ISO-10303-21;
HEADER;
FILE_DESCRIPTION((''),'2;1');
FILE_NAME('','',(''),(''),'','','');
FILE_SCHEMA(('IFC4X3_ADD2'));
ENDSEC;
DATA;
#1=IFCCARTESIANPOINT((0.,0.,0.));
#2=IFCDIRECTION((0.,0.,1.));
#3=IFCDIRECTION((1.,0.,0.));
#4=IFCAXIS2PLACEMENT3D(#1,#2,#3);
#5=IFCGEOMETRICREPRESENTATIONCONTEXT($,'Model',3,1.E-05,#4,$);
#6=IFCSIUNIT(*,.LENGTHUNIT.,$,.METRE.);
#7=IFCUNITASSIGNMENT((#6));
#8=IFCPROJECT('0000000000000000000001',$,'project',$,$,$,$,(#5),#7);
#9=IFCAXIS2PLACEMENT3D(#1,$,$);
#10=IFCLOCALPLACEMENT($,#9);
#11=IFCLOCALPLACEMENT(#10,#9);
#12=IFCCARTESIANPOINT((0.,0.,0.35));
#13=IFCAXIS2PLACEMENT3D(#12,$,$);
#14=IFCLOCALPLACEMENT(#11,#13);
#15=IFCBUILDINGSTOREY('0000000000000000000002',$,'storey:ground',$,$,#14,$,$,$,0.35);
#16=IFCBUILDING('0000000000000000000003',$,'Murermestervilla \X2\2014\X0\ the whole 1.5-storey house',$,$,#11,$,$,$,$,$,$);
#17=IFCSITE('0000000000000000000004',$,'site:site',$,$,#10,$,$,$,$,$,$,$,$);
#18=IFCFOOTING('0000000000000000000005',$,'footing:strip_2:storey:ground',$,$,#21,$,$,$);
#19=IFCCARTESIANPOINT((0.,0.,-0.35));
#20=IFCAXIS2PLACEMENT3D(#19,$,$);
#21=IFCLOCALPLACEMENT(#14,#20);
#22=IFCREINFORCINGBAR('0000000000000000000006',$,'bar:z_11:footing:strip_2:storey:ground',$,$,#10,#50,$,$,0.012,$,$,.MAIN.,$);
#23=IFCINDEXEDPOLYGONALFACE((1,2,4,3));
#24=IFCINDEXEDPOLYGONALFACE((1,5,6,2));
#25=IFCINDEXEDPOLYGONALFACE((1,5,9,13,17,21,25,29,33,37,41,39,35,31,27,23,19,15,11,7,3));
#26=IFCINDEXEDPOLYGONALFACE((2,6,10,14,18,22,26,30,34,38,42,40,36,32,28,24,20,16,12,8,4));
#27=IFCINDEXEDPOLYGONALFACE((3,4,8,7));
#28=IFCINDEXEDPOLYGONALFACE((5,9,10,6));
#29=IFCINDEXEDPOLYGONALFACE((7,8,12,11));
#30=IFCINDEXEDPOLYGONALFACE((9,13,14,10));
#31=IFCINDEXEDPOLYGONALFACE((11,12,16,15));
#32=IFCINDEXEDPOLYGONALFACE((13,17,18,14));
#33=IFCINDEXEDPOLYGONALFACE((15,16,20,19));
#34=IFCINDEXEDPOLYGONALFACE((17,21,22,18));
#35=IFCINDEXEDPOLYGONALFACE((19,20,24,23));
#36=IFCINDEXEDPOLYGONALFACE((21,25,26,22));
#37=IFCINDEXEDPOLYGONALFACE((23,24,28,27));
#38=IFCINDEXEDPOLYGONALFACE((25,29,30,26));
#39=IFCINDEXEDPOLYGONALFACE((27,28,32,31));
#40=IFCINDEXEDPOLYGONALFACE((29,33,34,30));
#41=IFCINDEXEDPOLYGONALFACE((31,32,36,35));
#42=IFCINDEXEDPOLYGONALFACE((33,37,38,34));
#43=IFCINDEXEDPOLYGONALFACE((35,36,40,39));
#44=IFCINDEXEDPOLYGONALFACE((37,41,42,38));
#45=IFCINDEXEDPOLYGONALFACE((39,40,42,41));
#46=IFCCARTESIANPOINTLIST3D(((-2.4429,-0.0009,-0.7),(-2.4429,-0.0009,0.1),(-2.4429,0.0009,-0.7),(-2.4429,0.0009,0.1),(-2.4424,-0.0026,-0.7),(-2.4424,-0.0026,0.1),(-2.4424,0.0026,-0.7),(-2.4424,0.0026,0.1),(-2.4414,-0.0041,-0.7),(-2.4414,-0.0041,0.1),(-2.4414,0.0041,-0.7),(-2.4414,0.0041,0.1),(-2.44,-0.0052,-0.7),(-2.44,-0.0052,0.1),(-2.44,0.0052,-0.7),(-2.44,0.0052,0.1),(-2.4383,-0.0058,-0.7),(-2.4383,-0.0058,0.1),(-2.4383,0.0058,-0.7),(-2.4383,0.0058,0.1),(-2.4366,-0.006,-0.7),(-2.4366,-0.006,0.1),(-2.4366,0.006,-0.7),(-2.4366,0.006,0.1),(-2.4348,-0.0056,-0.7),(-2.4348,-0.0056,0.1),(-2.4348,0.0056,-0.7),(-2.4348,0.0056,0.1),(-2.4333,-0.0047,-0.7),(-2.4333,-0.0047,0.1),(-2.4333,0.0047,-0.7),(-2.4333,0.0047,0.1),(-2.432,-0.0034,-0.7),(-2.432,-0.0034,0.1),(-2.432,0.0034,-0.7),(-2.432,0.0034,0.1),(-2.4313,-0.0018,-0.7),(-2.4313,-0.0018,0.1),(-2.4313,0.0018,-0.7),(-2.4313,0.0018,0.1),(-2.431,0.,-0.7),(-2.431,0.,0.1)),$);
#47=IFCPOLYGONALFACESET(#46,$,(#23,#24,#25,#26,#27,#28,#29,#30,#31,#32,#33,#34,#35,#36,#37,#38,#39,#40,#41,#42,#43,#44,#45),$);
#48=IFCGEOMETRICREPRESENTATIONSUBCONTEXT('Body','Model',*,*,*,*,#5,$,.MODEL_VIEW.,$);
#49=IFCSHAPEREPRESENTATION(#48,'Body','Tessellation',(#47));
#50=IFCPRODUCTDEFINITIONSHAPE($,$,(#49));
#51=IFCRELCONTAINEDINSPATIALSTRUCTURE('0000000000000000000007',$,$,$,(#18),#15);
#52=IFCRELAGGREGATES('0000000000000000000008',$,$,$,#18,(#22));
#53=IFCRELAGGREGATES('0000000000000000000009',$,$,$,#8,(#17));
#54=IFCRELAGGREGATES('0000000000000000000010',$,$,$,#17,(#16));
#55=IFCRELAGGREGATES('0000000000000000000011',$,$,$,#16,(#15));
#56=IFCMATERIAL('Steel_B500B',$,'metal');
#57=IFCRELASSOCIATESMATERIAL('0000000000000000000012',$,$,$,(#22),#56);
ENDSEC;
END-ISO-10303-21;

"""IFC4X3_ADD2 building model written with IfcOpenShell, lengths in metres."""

from ifc_helpers import new_model, entity, si_unit, frame, origin, origin_with_axes, place, context, subcontext, project, spatial, material, element, aggregate, save


model = new_model("IFC4X3_ADD2")

# Units and contexts
model_context = context("Model", 3, precision=1e-05, world=origin_with_axes())
body_context = subcontext(model_context, "Body", "Model", "MODEL_VIEW")
ifc_project = project(units=[si_unit("LENGTHUNIT", "METRE")], contexts=[model_context])

# Site, building, storey
placement_1 = place(None, origin())
site = spatial("IfcSite", under=ifc_project, at=placement_1, Name="site:site")
building_placement = place(placement_1, origin())
building = spatial("IfcBuilding", under=site, at=building_placement, Name="Murermestervilla — the whole 1.5-storey house")
storey_placement = place(building_placement, frame((0.0, 0.0, 0.35)))
storey = spatial("IfcBuildingStorey", under=building, at=storey_placement, Name="storey:ground", Elevation=0.35)

# Footing, reinforcing bar
placement_2 = place(storey_placement, frame((0.0, 0.0, -0.35)))
footing_1 = element("IfcFooting", 1, at=placement_2, inside=storey, Name="footing:strip_2:storey:ground")
ifc_material = material(Name="Steel_B500B", Category="metal")
reinforcing_bar_1 = element("IfcReinforcingBar", 2, at=placement_1, material=ifc_material, Name="bar:z_11:footing:strip_2:storey:ground", NominalDiameter=0.012, PredefinedType="MAIN", context=body_context, shape_type="AdvancedSweptSolid", body=[
    entity("IfcSweptDiskSolid", entity("IfcPolyline", [entity("IfcCartesianPoint", [-2.437, 0.0, -0.7]), entity("IfcCartesianPoint", [-2.437, 0.0, 0.1])]), 0.006),
])
aggregate(footing_1, [reinforcing_bar_1])

save(model, "model.ifc")
